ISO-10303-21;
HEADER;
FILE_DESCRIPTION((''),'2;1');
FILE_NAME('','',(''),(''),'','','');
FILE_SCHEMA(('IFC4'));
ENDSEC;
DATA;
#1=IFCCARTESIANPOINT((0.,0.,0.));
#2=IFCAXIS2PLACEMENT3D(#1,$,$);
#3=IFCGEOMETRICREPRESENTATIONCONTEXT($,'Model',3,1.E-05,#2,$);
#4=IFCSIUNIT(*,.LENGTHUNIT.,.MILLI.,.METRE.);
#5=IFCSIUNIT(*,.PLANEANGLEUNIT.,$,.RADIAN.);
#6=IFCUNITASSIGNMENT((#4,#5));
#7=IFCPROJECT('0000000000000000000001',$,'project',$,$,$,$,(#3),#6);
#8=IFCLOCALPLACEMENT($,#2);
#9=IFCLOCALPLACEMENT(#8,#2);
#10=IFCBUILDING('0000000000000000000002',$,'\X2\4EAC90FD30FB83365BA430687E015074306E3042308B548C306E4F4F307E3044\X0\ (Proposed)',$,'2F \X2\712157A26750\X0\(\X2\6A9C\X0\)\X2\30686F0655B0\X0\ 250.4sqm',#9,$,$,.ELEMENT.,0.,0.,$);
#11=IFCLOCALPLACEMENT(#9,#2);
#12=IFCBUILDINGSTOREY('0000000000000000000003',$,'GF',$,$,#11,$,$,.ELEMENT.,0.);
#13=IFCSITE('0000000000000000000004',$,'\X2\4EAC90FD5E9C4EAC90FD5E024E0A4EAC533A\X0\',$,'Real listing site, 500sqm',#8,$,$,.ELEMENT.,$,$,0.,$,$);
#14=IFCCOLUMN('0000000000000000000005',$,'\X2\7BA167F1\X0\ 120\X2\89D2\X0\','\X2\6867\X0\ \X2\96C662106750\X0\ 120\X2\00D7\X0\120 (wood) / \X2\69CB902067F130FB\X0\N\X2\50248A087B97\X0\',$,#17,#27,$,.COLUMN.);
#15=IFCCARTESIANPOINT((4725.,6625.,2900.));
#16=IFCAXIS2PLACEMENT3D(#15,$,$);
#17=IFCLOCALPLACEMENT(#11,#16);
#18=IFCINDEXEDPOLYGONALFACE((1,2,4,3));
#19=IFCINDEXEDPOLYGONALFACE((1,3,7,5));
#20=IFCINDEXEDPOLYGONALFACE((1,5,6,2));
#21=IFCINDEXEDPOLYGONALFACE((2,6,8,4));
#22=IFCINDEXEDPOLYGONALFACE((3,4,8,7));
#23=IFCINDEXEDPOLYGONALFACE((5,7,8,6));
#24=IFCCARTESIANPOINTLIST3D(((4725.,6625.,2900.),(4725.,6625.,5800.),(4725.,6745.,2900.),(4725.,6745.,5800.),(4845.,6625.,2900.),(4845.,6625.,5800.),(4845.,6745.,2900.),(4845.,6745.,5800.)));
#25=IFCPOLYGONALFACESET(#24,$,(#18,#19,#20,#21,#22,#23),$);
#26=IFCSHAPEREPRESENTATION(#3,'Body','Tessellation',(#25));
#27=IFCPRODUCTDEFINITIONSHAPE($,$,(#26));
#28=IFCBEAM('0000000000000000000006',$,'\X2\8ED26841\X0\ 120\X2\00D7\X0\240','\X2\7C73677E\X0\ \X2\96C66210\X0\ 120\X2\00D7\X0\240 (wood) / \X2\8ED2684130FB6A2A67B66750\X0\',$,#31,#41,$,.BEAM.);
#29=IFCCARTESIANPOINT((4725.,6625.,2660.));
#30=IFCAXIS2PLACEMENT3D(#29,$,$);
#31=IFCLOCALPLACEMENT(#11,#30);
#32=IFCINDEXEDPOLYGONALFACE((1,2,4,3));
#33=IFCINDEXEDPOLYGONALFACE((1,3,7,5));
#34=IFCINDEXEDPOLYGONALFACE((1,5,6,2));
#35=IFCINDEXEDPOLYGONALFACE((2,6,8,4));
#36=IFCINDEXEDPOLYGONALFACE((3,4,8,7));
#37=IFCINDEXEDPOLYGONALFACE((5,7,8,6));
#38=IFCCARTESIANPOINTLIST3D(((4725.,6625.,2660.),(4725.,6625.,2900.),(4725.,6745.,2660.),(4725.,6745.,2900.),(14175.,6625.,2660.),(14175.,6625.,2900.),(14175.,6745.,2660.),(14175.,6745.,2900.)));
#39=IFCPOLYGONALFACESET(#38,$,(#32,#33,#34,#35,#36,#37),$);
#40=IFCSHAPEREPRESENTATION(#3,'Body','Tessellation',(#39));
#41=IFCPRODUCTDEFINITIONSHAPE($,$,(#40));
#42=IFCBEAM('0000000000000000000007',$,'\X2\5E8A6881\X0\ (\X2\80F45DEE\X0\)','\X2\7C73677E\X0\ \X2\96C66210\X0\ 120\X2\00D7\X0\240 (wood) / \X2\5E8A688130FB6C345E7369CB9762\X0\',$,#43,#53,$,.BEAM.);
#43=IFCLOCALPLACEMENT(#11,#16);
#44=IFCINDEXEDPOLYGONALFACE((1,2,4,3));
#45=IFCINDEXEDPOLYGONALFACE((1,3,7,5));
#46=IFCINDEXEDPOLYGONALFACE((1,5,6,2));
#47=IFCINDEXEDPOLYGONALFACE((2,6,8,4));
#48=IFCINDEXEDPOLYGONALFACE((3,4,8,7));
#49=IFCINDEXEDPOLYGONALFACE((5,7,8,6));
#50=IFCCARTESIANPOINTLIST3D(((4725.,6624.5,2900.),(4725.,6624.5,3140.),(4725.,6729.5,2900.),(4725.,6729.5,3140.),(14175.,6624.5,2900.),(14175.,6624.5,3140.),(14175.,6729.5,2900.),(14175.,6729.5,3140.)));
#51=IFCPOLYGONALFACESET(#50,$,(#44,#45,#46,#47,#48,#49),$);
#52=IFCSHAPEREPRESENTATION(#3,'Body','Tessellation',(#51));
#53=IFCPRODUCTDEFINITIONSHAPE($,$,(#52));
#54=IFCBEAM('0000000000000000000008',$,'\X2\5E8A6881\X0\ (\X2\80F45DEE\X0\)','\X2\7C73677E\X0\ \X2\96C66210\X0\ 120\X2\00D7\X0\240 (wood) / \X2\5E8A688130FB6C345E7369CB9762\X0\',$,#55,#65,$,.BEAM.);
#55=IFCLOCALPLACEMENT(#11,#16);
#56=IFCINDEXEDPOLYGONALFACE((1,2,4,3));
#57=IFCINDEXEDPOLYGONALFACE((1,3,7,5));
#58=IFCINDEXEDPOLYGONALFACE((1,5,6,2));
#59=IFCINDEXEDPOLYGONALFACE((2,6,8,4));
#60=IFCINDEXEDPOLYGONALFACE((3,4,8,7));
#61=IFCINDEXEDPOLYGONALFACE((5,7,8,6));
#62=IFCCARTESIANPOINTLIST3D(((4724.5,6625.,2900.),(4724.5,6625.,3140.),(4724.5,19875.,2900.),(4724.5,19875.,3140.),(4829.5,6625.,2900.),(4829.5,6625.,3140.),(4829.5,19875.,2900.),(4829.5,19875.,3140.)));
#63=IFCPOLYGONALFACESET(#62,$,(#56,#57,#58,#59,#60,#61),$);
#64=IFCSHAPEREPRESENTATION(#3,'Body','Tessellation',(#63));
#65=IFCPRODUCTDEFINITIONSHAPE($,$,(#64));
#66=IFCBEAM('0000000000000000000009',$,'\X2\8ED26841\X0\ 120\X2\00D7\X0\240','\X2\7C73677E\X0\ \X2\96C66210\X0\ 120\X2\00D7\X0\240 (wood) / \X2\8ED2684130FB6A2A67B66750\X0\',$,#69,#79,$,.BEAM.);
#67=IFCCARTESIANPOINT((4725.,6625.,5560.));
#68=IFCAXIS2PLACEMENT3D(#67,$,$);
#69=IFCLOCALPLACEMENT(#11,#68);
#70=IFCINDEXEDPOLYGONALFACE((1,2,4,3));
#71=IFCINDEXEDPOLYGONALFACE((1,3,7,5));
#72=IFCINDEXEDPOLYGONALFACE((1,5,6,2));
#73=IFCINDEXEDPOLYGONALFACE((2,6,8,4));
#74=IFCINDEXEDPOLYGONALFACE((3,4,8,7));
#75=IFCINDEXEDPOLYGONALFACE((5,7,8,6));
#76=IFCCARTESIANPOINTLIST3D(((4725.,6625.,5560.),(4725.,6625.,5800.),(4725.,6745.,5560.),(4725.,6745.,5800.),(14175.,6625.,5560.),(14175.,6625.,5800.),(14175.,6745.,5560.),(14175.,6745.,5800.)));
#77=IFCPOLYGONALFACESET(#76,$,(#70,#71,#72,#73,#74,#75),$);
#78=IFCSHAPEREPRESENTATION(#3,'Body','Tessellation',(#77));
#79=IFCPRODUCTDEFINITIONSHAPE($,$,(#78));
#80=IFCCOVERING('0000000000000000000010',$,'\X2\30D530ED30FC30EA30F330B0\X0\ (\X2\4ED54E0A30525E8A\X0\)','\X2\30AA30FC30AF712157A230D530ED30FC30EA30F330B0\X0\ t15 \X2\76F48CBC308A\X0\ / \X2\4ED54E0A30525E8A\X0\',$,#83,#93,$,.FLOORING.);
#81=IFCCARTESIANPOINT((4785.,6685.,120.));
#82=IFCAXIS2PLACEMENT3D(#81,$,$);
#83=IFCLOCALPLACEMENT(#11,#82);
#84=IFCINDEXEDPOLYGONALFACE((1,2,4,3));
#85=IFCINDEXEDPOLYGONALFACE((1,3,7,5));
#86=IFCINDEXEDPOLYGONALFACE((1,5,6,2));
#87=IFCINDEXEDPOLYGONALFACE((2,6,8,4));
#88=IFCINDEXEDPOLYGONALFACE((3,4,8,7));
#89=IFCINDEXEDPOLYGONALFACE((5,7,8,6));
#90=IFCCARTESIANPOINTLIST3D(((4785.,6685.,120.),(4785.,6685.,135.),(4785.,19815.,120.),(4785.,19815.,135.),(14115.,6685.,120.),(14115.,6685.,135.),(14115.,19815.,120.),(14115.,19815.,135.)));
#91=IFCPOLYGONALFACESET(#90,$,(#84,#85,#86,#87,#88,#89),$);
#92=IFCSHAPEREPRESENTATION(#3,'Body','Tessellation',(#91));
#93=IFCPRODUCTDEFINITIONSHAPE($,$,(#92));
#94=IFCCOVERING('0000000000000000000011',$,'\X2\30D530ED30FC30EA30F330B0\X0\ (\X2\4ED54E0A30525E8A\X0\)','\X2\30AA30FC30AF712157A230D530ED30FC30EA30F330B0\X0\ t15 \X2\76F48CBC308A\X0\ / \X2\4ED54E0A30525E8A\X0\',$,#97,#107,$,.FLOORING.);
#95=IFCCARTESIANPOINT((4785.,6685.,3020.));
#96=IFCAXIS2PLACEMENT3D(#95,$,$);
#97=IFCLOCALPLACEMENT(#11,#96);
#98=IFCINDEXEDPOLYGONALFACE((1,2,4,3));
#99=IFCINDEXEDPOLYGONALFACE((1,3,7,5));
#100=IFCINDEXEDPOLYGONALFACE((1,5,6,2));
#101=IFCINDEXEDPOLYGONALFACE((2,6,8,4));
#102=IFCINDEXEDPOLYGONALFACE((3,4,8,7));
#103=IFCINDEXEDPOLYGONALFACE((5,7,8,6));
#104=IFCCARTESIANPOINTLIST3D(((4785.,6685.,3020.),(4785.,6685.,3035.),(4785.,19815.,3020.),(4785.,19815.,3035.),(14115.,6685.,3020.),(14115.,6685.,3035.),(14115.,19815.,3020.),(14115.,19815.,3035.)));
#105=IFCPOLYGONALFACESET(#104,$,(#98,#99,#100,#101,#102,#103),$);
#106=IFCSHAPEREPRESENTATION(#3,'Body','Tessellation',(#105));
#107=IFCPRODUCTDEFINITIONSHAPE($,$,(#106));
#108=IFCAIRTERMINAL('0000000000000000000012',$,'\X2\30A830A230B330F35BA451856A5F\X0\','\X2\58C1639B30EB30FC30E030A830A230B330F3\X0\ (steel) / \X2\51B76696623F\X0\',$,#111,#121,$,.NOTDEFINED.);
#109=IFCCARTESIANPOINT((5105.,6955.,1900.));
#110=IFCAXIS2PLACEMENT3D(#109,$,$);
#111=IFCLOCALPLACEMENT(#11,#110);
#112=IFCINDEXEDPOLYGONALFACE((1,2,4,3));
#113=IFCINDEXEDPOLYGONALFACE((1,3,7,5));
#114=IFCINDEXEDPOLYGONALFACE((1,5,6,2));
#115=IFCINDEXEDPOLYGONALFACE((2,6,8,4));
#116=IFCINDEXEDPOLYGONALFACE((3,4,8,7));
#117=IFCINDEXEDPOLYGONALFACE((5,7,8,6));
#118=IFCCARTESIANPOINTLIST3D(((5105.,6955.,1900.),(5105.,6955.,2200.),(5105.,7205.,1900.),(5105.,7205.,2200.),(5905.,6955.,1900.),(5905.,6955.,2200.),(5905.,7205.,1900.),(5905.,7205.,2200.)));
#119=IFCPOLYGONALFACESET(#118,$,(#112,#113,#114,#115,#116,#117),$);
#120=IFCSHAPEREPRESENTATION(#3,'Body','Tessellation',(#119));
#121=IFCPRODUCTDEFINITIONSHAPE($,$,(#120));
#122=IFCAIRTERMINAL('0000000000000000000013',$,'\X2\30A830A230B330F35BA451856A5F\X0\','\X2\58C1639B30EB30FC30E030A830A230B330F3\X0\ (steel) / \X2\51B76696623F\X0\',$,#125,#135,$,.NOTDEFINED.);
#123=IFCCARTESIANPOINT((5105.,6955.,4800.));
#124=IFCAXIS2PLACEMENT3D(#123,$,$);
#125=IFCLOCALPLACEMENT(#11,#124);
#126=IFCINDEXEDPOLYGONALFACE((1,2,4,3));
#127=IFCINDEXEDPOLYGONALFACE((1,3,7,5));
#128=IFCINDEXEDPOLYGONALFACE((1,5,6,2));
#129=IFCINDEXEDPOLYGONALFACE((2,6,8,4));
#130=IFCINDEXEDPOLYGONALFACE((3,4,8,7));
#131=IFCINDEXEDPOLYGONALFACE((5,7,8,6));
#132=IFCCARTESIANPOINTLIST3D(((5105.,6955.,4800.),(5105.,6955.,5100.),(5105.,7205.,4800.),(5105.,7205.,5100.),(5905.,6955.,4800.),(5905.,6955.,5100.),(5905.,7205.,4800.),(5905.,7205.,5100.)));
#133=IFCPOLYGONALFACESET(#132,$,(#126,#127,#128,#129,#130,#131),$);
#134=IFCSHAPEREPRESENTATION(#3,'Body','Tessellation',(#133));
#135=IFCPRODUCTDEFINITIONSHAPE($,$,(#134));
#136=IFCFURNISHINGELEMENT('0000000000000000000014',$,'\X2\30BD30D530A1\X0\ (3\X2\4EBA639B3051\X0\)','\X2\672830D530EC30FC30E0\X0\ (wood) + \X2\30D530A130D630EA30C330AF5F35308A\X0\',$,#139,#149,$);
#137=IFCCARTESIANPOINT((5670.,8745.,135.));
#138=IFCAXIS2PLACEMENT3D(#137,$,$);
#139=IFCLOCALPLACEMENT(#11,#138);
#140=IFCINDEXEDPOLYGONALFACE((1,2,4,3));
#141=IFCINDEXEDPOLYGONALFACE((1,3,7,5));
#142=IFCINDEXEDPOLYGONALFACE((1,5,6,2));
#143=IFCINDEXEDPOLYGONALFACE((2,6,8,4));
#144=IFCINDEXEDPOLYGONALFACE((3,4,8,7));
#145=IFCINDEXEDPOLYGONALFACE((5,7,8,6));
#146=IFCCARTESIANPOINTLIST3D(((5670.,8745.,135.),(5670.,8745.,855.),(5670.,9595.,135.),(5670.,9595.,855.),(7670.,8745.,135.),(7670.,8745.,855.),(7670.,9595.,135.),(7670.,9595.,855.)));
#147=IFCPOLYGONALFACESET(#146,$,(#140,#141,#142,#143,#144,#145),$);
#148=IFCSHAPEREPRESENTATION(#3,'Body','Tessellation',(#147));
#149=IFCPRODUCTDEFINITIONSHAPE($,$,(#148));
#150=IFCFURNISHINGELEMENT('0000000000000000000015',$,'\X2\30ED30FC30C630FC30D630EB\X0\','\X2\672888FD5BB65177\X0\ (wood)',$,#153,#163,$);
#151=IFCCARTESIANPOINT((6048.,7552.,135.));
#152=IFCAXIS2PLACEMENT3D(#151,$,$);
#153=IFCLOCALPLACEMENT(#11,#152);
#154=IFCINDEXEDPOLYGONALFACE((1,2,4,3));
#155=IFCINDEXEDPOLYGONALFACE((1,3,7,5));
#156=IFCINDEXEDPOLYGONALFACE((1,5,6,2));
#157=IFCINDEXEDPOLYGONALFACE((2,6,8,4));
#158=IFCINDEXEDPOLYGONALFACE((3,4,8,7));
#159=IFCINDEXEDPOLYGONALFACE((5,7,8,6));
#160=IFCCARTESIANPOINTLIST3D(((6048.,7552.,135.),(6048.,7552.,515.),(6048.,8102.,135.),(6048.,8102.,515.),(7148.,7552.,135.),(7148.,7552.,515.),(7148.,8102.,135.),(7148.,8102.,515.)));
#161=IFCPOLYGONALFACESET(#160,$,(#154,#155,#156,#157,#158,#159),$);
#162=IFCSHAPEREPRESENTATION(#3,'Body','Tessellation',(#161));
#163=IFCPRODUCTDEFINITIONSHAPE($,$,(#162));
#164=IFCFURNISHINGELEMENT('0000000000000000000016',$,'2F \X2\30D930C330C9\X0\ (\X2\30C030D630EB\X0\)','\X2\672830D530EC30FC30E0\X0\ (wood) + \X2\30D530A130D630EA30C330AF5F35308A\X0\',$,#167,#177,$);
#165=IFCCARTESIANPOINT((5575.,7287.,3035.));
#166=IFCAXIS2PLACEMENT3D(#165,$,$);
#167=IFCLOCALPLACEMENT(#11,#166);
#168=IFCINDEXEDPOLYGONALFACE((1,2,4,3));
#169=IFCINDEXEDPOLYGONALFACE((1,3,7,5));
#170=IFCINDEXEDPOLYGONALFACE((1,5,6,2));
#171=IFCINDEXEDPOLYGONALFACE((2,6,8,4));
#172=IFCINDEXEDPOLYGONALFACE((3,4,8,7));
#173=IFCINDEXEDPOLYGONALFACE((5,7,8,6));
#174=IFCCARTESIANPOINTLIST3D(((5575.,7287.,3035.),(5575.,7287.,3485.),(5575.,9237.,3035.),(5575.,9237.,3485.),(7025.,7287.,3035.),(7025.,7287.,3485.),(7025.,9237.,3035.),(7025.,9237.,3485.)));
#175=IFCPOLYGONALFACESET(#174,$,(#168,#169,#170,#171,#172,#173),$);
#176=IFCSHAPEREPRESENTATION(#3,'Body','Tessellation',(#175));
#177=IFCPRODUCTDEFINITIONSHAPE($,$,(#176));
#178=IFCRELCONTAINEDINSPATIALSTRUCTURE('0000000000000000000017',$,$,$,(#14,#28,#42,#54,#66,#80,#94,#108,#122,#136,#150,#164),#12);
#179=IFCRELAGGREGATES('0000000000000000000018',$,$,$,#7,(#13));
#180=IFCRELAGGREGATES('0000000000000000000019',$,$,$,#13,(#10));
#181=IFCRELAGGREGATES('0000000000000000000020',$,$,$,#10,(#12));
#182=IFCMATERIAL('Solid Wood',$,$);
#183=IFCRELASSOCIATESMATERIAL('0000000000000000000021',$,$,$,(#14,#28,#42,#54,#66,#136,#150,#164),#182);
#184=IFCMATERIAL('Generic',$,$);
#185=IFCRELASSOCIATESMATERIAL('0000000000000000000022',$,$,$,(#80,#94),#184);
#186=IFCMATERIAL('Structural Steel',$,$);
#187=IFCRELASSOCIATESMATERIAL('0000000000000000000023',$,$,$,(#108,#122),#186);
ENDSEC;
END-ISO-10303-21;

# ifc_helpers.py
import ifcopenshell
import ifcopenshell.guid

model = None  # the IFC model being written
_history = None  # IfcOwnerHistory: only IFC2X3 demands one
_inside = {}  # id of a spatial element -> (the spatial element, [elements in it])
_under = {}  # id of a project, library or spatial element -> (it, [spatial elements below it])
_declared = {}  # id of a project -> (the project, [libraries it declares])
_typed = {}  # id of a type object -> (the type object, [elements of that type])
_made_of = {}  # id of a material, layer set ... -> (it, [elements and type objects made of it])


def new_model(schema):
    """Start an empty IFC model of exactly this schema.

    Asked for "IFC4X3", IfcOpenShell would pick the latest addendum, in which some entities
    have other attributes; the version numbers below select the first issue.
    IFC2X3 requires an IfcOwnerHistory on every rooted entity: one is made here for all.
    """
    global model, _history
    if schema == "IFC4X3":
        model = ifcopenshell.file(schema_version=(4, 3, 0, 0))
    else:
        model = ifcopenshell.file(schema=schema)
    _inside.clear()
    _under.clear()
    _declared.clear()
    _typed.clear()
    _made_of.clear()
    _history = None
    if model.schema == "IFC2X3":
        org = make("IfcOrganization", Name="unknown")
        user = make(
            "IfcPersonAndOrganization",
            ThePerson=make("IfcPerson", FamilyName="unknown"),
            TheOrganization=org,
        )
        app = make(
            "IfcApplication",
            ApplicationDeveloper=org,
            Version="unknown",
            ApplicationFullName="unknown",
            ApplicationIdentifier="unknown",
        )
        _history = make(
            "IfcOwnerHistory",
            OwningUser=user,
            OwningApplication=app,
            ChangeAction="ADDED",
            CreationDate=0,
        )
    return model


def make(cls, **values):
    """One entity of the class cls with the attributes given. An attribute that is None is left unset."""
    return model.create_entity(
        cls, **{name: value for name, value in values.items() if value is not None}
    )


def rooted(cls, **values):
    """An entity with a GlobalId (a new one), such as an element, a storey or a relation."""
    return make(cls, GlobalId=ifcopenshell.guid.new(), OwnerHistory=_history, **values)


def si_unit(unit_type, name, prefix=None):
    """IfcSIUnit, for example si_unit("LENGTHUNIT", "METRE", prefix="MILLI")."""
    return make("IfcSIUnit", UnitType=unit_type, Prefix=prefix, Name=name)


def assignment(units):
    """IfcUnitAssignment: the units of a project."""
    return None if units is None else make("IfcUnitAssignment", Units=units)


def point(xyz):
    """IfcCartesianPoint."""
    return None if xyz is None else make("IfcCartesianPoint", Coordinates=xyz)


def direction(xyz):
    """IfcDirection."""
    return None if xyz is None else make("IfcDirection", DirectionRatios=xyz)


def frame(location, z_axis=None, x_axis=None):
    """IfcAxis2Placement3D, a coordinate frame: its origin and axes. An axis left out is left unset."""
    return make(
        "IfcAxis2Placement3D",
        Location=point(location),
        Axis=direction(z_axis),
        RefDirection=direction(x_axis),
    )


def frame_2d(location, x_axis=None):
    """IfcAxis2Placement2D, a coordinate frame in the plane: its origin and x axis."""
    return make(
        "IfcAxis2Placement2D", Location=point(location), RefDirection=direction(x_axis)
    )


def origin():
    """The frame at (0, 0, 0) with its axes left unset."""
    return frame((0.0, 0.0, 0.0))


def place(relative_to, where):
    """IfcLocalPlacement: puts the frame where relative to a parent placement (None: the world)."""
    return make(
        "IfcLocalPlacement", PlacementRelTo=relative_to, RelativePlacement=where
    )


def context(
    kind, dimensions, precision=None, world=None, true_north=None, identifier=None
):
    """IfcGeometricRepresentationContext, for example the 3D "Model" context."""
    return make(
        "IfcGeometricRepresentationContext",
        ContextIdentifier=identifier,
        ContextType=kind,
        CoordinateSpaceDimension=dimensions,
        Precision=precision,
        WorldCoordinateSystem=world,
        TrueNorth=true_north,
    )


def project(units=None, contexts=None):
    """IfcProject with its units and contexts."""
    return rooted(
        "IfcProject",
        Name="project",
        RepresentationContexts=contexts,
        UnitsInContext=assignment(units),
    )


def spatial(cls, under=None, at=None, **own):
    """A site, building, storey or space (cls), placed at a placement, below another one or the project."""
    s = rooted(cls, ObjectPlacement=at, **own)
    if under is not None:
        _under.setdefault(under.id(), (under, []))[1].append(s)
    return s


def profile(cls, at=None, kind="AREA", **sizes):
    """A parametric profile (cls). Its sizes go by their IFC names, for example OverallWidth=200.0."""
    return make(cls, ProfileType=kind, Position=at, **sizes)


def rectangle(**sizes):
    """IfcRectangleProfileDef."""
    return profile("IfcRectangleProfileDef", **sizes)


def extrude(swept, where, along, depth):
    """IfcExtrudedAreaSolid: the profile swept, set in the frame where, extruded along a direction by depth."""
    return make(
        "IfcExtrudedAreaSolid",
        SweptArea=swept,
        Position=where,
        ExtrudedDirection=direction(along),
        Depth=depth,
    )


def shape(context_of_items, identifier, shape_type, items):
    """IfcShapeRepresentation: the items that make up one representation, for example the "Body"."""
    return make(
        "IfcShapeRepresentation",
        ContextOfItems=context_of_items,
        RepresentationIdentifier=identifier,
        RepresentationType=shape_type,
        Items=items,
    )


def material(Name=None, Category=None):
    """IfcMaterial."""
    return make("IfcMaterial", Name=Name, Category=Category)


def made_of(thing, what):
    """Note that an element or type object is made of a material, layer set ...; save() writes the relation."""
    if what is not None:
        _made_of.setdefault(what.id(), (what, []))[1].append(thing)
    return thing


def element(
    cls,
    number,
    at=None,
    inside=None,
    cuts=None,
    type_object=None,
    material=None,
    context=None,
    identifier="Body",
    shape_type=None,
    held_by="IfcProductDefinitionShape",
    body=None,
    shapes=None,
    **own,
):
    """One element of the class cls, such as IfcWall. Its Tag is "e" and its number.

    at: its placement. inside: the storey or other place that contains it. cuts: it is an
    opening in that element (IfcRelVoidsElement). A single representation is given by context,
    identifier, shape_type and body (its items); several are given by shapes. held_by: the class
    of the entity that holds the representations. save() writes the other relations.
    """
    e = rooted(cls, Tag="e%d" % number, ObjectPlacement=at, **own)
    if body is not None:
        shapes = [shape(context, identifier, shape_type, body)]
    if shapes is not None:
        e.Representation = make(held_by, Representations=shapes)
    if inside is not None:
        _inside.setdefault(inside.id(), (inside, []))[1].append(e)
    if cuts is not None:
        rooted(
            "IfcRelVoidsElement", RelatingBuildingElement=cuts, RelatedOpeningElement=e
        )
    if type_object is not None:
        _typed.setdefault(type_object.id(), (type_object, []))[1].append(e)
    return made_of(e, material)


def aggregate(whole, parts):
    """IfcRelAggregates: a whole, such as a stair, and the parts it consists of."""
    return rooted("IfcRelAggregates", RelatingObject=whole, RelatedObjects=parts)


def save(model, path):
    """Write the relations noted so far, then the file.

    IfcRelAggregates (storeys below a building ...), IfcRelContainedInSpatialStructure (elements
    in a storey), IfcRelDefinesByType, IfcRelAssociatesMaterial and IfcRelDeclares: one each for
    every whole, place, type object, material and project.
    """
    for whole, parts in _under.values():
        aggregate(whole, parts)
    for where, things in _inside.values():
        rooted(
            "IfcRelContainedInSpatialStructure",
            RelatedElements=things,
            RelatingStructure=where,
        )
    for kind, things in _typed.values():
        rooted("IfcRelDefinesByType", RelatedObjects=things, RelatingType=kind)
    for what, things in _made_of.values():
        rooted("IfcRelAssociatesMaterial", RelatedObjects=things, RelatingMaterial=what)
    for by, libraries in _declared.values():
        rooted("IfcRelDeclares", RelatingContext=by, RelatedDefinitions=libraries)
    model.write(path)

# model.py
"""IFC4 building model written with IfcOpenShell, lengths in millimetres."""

from ifc_helpers import new_model, si_unit, frame, frame_2d, origin, place, context, project, spatial, rectangle, extrude, material, element, save


model = new_model("IFC4")

# Units and contexts
model_context = context("Model", 3, precision=1e-05, world=origin())
ifc_project = project(units=[si_unit("LENGTHUNIT", "METRE", prefix="MILLI"), si_unit("PLANEANGLEUNIT", "RADIAN")], contexts=[model_context])

# Site, building, storey
site_placement = place(None, origin())
site = spatial("IfcSite", under=ifc_project, at=site_placement, Name="京都府京都市上京区", ObjectType="Real listing site, 500sqm", CompositionType="ELEMENT", RefElevation=0.0)
building_placement = place(site_placement, origin())
building = spatial("IfcBuilding", under=site, at=building_placement, Name="京都・茶室と縁側のある和の住まい (Proposed)", ObjectType="2F 無垢材(檜)と漆喰 250.4sqm", CompositionType="ELEMENT", ElevationOfRefHeight=0.0, ElevationOfTerrain=0.0)
storey_placement = place(building_placement, origin())
storey = spatial("IfcBuildingStorey", under=building, at=storey_placement, Name="GF", CompositionType="ELEMENT", Elevation=0.0)

# Column
ifc_material_1 = material(Name="Solid Wood")
column_1_placement = place(storey_placement, frame((4725.0, 6625.0, 2900.0)))
element("IfcColumn", 1, at=column_1_placement, inside=storey, material=ifc_material_1, Name="管柱 120角", Description="桧 集成材 120×120 (wood) / 構造柱・N値計算", PredefinedType="COLUMN", context=model_context, shape_type="SweptSolid", body=[
    extrude(rectangle(XDim=120.0, YDim=120.0, at=frame_2d((60.0, 60.0))), frame((4725.0, 6625.0, 2900.0)), (0.0, 0.0, 1.0), 2900.0),
])

# Beams
beam_1_placement = place(storey_placement, frame((4725.0, 6625.0, 2660.0)))
element("IfcBeam", 2, at=beam_1_placement, inside=storey, material=ifc_material_1, Name="軒桁 120×240", Description="米松 集成 120×240 (wood) / 軒桁・横架材", PredefinedType="BEAM", context=model_context, shape_type="SweptSolid", body=[
    extrude(rectangle(XDim=9450.0, YDim=120.0, at=frame_2d((4725.0, 60.0))), frame((4725.0, 6625.0, 2660.0)), (0.0, 0.0, 1.0), 240.0),
])
beam_2_placement = place(storey_placement, frame((4725.0, 6625.0, 2900.0)))
element("IfcBeam", 3, at=beam_2_placement, inside=storey, material=ifc_material_1, Name="床梁 (胴差)", Description="米松 集成 120×240 (wood) / 床梁・水平構面", PredefinedType="BEAM", context=model_context, shape_type="SweptSolid", body=[
    extrude(rectangle(XDim=9450.0, YDim=105.0, at=frame_2d((4725.0, 52.0))), frame((4725.0, 6625.0, 2900.0)), (0.0, 0.0, 1.0), 240.0),
])
beam_3_placement = place(storey_placement, frame((4725.0, 6625.0, 2900.0)))
element("IfcBeam", 4, at=beam_3_placement, inside=storey, material=ifc_material_1, Name="床梁 (胴差)", Description="米松 集成 120×240 (wood) / 床梁・水平構面", PredefinedType="BEAM", context=model_context, shape_type="SweptSolid", body=[
    extrude(rectangle(XDim=105.0, YDim=13250.0, at=frame_2d((52.0, 6625.0))), frame((4725.0, 6625.0, 2900.0)), (0.0, 0.0, 1.0), 240.0),
])
beam_4_placement = place(storey_placement, frame((4725.0, 6625.0, 5560.0)))
element("IfcBeam", 5, at=beam_4_placement, inside=storey, material=ifc_material_1, Name="軒桁 120×240", Description="米松 集成 120×240 (wood) / 軒桁・横架材", PredefinedType="BEAM", context=model_context, shape_type="SweptSolid", body=[
    extrude(rectangle(XDim=9450.0, YDim=120.0, at=frame_2d((4725.0, 60.0))), frame((4725.0, 6625.0, 5560.0)), (0.0, 0.0, 1.0), 240.0),
])

# Coverings
ifc_material_2 = material(Name="Generic")
covering_1_placement = place(storey_placement, frame((4785.0, 6685.0, 120.0)))
element("IfcCovering", 6, at=covering_1_placement, inside=storey, material=ifc_material_2, Name="フローリング (仕上げ床)", Description="オーク無垢フローリング t15 直貼り / 仕上げ床", PredefinedType="FLOORING", context=model_context, shape_type="SweptSolid", body=[
    extrude(rectangle(XDim=9330.0, YDim=13130.0, at=frame_2d((4665.0, 6565.0))), frame((4785.0, 6685.0, 120.0)), (0.0, 0.0, 1.0), 15.0),
])
covering_2_placement = place(storey_placement, frame((4785.0, 6685.0, 3020.0)))
element("IfcCovering", 7, at=covering_2_placement, inside=storey, material=ifc_material_2, Name="フローリング (仕上げ床)", Description="オーク無垢フローリング t15 直貼り / 仕上げ床", PredefinedType="FLOORING", context=model_context, shape_type="SweptSolid", body=[
    extrude(rectangle(XDim=9330.0, YDim=13130.0, at=frame_2d((4665.0, 6565.0))), frame((4785.0, 6685.0, 3020.0)), (0.0, 0.0, 1.0), 15.0),
])

# Air terminals
ifc_material_3 = material(Name="Structural Steel")
air_terminal_1_placement = place(storey_placement, frame((5105.0, 6955.0, 1900.0)))
element("IfcAirTerminal", 8, at=air_terminal_1_placement, inside=storey, material=ifc_material_3, Name="エアコン室内機", Description="壁掛ルームエアコン (steel) / 冷暖房", PredefinedType="NOTDEFINED", context=model_context, shape_type="SweptSolid", body=[
    extrude(rectangle(XDim=800.0, YDim=250.0, at=frame_2d((400.0, 125.0))), frame((5105.0, 6955.0, 1900.0)), (0.0, 0.0, 1.0), 300.0),
])
air_terminal_2_placement = place(storey_placement, frame((5105.0, 6955.0, 4800.0)))
element("IfcAirTerminal", 9, at=air_terminal_2_placement, inside=storey, material=ifc_material_3, Name="エアコン室内機", Description="壁掛ルームエアコン (steel) / 冷暖房", PredefinedType="NOTDEFINED", context=model_context, shape_type="SweptSolid", body=[
    extrude(rectangle(XDim=800.0, YDim=250.0, at=frame_2d((400.0, 125.0))), frame((5105.0, 6955.0, 4800.0)), (0.0, 0.0, 1.0), 300.0),
])

# Furnishing elements
furnishing_1_placement = place(storey_placement, frame((5670.0, 8745.0, 135.0)))
element("IfcFurnishingElement", 10, at=furnishing_1_placement, inside=storey, material=ifc_material_1, Name="ソファ (3人掛け)", Description="木フレーム (wood) + ファブリック張り", context=model_context, shape_type="SweptSolid", body=[
    extrude(rectangle(XDim=2000.0, YDim=850.0, at=frame_2d((1000.0, 425.0))), frame((5670.0, 8745.0, 135.0)), (0.0, 0.0, 1.0), 720.0),
])
furnishing_2_placement = place(storey_placement, frame((6048.0, 7552.0, 135.0)))
element("IfcFurnishingElement", 11, at=furnishing_2_placement, inside=storey, material=ifc_material_1, Name="ローテーブル", Description="木製家具 (wood)", context=model_context, shape_type="SweptSolid", body=[
    extrude(rectangle(XDim=1100.0, YDim=550.0, at=frame_2d((550.0, 275.0))), frame((6048.0, 7552.0, 135.0)), (0.0, 0.0, 1.0), 380.0),
])
furnishing_3_placement = place(storey_placement, frame((5575.0, 7287.0, 3035.0)))
element("IfcFurnishingElement", 12, at=furnishing_3_placement, inside=storey, material=ifc_material_1, Name="2F ベッド (ダブル)", Description="木フレーム (wood) + ファブリック張り", context=model_context, shape_type="SweptSolid", body=[
    extrude(rectangle(XDim=1450.0, YDim=1950.0, at=frame_2d((725.0, 975.0))), frame((5575.0, 7287.0, 3035.0)), (0.0, 0.0, 1.0), 450.0),
])

save(model, "model.ifc")
